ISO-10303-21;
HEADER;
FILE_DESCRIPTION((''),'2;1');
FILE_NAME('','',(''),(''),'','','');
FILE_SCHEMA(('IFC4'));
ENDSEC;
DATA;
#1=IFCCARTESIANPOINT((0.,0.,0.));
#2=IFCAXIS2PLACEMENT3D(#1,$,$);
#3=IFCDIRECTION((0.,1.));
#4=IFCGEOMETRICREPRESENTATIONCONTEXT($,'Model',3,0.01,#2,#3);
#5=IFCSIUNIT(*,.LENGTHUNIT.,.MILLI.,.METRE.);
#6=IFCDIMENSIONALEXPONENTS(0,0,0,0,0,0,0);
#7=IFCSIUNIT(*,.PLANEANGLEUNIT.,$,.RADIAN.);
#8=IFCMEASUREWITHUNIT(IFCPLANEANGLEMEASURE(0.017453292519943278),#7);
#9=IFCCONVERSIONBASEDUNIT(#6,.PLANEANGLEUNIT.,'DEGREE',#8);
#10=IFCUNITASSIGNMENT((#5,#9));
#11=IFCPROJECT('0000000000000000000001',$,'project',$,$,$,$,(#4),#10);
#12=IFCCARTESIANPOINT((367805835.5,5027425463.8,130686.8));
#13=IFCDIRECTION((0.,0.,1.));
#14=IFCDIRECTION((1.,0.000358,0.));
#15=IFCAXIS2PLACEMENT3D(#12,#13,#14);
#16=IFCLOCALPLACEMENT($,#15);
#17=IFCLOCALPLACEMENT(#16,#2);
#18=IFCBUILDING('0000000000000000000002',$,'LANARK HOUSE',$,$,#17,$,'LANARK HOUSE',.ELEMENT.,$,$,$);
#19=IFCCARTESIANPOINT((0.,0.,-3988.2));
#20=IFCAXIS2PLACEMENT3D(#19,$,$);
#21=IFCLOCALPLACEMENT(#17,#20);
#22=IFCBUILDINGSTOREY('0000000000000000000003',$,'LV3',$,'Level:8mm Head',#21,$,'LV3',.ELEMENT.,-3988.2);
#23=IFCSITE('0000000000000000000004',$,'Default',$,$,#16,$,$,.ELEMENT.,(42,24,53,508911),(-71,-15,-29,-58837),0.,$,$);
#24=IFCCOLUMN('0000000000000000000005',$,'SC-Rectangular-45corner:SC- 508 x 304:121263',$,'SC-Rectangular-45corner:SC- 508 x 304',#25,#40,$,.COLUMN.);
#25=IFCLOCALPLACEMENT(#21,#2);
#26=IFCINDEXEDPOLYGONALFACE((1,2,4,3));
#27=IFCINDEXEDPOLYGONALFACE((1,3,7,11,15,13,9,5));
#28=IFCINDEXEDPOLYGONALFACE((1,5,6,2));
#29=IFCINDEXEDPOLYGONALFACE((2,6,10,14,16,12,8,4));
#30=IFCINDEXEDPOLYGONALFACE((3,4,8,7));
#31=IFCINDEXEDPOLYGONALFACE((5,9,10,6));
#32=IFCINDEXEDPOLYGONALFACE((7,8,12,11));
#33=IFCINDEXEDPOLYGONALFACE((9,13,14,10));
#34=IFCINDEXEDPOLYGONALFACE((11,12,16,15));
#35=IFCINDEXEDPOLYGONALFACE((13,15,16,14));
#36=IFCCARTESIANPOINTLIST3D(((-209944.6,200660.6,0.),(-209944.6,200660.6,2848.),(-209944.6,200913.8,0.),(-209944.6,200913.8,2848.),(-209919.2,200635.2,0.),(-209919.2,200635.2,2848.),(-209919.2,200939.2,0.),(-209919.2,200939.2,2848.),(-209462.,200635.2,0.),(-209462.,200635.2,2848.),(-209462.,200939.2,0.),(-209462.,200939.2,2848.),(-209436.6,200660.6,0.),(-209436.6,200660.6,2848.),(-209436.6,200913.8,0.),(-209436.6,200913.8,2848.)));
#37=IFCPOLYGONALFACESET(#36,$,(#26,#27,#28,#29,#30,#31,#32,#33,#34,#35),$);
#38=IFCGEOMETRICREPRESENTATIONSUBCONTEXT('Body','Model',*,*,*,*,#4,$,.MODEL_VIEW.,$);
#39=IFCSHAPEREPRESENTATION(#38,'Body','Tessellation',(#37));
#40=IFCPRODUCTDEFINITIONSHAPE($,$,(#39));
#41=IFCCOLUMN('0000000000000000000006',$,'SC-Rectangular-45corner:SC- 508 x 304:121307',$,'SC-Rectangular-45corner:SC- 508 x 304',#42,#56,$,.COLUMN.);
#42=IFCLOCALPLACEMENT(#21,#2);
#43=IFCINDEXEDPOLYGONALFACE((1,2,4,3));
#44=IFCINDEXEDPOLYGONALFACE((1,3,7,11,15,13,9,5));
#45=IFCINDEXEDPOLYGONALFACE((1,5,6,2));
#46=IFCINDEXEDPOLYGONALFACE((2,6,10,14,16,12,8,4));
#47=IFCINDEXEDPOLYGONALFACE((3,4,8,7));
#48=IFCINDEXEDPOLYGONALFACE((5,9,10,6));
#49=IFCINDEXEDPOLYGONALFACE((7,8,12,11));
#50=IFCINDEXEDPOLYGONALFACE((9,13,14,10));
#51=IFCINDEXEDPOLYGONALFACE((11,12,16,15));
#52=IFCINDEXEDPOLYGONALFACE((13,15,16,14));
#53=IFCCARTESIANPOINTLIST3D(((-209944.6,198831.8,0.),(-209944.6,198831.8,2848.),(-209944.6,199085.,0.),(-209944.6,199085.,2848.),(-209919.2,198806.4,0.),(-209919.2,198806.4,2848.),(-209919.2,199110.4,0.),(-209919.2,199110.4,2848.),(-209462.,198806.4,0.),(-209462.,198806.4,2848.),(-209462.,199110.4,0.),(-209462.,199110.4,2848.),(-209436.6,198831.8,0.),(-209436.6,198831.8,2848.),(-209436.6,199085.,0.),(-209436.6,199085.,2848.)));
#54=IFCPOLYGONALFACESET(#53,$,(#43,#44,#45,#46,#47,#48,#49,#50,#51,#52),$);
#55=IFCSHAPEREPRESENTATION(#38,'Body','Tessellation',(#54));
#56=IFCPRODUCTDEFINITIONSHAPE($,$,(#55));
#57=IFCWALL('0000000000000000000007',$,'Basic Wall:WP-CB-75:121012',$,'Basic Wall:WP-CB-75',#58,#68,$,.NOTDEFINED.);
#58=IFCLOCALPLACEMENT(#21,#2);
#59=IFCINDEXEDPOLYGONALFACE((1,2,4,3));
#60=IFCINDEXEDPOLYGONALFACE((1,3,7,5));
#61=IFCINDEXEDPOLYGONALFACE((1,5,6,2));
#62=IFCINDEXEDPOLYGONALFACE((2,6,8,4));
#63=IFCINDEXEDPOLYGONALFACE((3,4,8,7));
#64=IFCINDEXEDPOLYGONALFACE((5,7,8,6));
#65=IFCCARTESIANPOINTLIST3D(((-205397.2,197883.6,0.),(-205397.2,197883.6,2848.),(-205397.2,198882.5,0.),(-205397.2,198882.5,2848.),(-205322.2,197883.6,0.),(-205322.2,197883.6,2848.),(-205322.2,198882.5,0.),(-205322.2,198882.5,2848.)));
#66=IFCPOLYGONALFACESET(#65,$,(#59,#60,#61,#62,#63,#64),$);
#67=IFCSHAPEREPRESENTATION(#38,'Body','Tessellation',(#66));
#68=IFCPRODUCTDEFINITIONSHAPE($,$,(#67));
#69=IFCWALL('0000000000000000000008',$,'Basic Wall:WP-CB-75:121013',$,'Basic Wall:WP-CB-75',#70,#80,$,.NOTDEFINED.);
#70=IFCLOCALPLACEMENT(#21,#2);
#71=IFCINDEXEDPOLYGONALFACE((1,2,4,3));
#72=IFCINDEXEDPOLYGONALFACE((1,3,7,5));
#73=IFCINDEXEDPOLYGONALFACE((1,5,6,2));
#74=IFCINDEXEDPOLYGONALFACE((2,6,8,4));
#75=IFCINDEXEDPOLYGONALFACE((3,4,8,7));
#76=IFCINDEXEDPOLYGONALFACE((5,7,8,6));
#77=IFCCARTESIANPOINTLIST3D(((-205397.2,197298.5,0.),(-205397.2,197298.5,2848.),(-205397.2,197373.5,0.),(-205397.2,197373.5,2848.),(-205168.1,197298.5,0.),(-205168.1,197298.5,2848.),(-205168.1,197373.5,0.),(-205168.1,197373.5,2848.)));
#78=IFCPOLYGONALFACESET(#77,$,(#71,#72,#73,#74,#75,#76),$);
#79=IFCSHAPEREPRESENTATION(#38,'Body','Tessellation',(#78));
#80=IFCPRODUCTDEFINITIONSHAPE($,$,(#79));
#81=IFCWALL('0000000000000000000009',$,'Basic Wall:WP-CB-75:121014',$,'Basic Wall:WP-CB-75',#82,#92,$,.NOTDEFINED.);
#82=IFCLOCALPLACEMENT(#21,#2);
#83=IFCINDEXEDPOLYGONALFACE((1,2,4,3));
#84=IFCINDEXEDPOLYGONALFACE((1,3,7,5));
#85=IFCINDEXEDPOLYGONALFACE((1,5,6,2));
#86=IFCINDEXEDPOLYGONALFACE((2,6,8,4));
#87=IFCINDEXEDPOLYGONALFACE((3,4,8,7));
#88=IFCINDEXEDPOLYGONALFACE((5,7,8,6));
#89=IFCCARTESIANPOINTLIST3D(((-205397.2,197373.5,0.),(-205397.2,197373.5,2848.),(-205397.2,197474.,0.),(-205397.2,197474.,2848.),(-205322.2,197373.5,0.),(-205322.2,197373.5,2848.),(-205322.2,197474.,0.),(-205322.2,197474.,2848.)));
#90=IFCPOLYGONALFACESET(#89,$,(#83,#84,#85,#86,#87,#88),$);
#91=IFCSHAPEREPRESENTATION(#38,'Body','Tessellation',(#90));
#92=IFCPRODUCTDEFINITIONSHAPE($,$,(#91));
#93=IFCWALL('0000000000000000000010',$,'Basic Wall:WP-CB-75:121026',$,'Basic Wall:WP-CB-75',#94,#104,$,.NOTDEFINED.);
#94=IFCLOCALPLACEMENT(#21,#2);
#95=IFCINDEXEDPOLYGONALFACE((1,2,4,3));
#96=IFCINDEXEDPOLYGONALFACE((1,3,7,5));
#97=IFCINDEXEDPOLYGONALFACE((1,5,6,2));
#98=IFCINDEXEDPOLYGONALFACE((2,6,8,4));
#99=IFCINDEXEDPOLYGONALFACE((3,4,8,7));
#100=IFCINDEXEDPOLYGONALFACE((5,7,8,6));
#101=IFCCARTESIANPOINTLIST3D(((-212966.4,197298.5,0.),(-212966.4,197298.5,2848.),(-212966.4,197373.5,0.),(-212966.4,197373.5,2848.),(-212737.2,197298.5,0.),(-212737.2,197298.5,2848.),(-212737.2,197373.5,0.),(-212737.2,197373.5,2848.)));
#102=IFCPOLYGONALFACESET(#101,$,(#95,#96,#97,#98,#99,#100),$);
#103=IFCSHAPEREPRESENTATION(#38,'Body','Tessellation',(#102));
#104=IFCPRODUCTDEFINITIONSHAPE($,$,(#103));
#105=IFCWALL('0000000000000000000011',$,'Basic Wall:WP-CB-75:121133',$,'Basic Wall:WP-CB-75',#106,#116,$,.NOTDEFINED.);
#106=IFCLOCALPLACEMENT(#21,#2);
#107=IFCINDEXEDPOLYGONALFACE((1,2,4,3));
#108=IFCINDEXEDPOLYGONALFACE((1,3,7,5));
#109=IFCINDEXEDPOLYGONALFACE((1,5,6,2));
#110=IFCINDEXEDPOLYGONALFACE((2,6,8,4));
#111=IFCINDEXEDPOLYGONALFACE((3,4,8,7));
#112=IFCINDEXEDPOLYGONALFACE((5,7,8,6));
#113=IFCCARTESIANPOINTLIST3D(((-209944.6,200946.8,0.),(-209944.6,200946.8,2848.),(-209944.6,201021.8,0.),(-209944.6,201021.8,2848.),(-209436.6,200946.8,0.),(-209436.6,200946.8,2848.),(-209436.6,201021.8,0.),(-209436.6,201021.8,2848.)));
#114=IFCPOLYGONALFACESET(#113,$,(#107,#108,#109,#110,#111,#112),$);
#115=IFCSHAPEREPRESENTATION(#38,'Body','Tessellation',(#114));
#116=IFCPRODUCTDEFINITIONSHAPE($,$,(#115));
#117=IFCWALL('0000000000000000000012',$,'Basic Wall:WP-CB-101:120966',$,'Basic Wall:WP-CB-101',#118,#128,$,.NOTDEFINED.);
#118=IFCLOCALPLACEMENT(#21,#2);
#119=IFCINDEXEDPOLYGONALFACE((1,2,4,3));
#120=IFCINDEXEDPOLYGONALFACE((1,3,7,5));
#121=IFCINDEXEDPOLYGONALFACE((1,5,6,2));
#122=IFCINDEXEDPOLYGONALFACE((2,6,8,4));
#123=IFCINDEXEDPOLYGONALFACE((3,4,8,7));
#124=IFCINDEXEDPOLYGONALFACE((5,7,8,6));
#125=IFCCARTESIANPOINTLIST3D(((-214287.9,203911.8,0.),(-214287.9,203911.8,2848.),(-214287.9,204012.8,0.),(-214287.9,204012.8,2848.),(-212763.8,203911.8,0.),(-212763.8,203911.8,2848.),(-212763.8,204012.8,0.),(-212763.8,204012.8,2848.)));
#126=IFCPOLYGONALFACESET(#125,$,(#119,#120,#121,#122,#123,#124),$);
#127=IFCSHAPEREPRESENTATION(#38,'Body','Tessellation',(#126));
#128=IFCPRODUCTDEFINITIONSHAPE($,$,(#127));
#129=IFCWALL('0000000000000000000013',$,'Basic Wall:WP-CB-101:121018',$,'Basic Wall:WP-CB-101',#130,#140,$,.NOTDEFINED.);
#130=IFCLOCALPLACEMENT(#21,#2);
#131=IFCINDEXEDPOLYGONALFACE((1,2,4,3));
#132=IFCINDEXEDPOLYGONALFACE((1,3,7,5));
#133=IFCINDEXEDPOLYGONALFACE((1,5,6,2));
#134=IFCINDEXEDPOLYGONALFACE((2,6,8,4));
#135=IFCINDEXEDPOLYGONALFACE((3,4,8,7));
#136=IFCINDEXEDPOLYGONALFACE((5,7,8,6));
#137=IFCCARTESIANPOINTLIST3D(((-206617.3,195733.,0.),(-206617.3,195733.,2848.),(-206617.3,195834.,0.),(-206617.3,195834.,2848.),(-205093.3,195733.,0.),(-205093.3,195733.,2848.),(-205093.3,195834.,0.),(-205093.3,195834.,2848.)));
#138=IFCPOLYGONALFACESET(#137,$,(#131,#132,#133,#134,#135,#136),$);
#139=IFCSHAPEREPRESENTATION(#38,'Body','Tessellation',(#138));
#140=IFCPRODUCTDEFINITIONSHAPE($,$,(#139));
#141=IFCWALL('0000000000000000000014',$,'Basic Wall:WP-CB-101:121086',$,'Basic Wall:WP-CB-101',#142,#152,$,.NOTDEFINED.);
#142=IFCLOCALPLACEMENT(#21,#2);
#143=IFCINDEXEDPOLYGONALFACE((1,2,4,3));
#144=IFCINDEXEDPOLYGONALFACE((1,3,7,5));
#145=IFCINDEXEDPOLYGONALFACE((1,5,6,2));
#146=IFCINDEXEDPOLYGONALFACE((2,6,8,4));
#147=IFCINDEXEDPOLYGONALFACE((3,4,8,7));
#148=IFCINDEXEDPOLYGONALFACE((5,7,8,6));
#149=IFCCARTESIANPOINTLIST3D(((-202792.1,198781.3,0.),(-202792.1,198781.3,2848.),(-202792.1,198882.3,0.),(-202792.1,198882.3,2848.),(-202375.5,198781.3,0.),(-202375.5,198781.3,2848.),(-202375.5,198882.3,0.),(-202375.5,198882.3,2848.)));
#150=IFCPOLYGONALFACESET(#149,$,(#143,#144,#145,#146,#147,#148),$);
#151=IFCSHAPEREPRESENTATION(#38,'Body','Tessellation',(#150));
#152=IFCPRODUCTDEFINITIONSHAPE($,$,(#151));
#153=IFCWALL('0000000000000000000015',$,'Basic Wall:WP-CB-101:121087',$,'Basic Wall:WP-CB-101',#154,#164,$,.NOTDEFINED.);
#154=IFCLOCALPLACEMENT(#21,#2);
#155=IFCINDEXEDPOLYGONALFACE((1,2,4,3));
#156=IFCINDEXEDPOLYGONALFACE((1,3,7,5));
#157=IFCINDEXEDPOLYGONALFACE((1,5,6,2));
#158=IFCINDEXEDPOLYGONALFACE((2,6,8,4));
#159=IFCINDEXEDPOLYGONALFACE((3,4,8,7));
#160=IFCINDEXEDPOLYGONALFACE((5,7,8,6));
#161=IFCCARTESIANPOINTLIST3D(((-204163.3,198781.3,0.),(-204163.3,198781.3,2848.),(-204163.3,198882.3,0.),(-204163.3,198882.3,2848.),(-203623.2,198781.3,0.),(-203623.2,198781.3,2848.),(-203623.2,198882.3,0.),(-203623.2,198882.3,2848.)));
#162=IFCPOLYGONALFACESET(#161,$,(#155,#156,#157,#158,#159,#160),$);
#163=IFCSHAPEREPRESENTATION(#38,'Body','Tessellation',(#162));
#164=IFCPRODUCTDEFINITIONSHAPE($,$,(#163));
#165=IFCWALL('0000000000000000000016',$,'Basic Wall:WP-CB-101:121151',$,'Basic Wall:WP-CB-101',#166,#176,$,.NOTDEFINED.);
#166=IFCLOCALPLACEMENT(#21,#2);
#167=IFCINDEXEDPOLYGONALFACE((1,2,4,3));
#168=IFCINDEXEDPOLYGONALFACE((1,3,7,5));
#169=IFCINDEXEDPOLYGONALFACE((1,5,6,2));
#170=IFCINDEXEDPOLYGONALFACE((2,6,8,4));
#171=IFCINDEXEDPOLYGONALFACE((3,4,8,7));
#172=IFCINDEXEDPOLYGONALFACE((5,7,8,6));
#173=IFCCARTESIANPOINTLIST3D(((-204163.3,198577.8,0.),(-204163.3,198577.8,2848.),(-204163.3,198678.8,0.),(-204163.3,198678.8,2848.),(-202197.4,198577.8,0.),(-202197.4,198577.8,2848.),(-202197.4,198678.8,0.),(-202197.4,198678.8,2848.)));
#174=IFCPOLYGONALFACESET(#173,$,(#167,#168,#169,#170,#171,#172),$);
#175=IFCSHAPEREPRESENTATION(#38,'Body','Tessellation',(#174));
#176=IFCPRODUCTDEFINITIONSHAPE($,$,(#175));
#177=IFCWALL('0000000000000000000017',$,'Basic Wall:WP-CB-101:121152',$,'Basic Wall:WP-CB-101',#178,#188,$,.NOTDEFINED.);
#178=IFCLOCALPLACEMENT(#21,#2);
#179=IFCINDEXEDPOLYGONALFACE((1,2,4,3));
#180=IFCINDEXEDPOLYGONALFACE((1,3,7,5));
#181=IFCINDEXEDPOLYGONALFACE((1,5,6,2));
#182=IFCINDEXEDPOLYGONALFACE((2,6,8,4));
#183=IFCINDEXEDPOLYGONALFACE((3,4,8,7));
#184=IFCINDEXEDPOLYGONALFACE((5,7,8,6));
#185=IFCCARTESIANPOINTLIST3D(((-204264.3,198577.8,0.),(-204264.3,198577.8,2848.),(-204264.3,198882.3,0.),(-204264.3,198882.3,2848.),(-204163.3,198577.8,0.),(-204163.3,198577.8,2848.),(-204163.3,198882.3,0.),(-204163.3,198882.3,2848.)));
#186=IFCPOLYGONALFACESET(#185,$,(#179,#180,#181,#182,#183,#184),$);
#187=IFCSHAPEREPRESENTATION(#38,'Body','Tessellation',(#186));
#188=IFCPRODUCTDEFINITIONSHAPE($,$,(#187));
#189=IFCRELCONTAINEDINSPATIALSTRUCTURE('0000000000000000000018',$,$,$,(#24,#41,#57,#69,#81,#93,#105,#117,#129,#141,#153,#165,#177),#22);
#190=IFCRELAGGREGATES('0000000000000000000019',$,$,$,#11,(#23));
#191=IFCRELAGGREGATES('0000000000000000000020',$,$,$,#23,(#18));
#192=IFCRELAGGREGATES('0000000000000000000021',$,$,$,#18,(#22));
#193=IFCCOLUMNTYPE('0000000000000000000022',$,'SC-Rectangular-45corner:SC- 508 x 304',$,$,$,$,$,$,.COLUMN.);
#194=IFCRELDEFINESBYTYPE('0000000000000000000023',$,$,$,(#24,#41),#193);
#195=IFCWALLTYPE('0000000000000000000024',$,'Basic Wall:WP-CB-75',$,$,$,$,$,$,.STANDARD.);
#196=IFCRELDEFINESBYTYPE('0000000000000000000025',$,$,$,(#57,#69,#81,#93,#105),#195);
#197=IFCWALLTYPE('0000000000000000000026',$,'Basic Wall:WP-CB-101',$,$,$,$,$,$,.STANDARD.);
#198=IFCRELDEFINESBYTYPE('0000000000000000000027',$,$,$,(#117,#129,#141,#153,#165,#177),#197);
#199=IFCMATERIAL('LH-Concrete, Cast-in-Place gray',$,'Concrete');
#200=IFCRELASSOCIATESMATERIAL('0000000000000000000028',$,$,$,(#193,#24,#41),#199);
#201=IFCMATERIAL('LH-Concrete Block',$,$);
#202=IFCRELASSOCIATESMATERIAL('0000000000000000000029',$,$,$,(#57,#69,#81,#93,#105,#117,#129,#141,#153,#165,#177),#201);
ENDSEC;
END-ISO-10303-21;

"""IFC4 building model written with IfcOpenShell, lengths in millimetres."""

from ifc_helpers import new_model, entity, si_unit, converted_unit, direction, frame, origin, place, context, subcontext, project, spatial, indexed_curve, outline, extrude, source, transform, mapped, material, type_object, type_shapes, element, save


model = new_model("IFC4")

# Units and contexts
model_context = context("Model", 3, precision=0.01, world=origin(), true_north=direction((0.0, 1.0)))
body_context = subcontext(model_context, "Body", "Model", "MODEL_VIEW")
ifc_project = project(units=[si_unit("LENGTHUNIT", "METRE", prefix="MILLI"), converted_unit("PLANEANGLEUNIT", "DEGREE", entity("IfcPlaneAngleMeasure", 0.017453292519943278), si_unit("PLANEANGLEUNIT", "RADIAN"), dimensions=[0, 0, 0, 0, 0, 0, 0])], contexts=[model_context])

# Site, building, storey
site_placement = place(None, frame((367805835.5, 5027425463.8, 130686.8), z_axis=(0.0, 0.0, 1.0), x_axis=(1.0, 0.000358, 0.0)))
site = spatial("IfcSite", under=ifc_project, at=site_placement, Name="Default", CompositionType="ELEMENT", RefLatitude=(42, 24, 53, 508911), RefLongitude=(-71, -15, -29, -58837), RefElevation=0.0)
building_placement = place(site_placement, origin())
building = spatial("IfcBuilding", under=site, at=building_placement, Name="LANARK HOUSE", LongName="LANARK HOUSE", CompositionType="ELEMENT")
storey_placement = place(building_placement, frame((0.0, 0.0, -3988.2)))
storey = spatial("IfcBuildingStorey", under=building, at=storey_placement, Name="LV3", ObjectType="Level:8mm Head", LongName="LV3", CompositionType="ELEMENT", Elevation=-3988.2)

# Columns
ifc_material_1 = material(Name="LH-Concrete, Cast-in-Place gray", Category="Concrete")
column_type = type_object("IfcColumnType", Name="SC-Rectangular-45corner:SC- 508 x 304", PredefinedType="COLUMN", material=ifc_material_1)
shared_shape = source(origin(), body_context, "Body", "SweptSolid", [
    extrude(outline(indexed_curve([(-228.6, -152.0), (228.6, -152.0), (254.0, -126.6), (254.0, 126.6), (228.6, 152.0), (-228.6, 152.0), (-254.0, 126.6), (-254.0, -126.6), (-228.6, -152.0)], self_intersect=False)), frame((0.0, 0.0, -3988.2), z_axis=(0.0, 0.0, 1.0), x_axis=(-1.0, 0.0, 0.0)), (0.0, 0.0, 1.0), 2848.0),
])
type_shapes(column_type, [shared_shape])
for number, where, name in (
    (1, (-209690.6, 200787.2, 3988.2), "SC-Rectangular-45corner:SC- 508 x 304:121263"),
    (2, (-209690.6, 198958.4, 3988.2), "SC-Rectangular-45corner:SC- 508 x 304:121307"),
):
    element("IfcColumn", number, at=place(storey_placement, frame(where)), inside=storey, type_object=column_type, material=ifc_material_1, Name=name, ObjectType="SC-Rectangular-45corner:SC- 508 x 304", PredefinedType="COLUMN", context=body_context, shape_type="MappedRepresentation", body=[
        mapped(shared_shape, transform((0.0, 0.0, 0.0), scale=1.0)),
    ])

# Walls
ifc_material_2 = material(Name="LH-Concrete Block")
wall_type_1 = type_object("IfcWallType", Name="Basic Wall:WP-CB-75", PredefinedType="STANDARD")
wall_1_placement = place(storey_placement, frame((-205359.7, 198882.5, 0.0), z_axis=(0.0, 0.0, 1.0), x_axis=(0.0, -1.0, 0.0)))
element("IfcWall", 3, at=wall_1_placement, inside=storey, type_object=wall_type_1, material=ifc_material_2, Name="Basic Wall:WP-CB-75:121012", ObjectType="Basic Wall:WP-CB-75", PredefinedType="NOTDEFINED", context=body_context, shape_type="SweptSolid", body=[
    extrude(outline(indexed_curve([(998.9, 37.5), (0.0, 37.5), (0.0, -37.5), (998.9, -37.5), (998.9, 37.5)], self_intersect=False)), origin(), (0.0, 0.0, 1.0), 2848.0),
])
wall_2_placement = place(storey_placement, frame((-205168.1, 197336.0, 0.0), z_axis=(0.0, 0.0, 1.0), x_axis=(-1.0, 0.0, 0.0)))
element("IfcWall", 4, at=wall_2_placement, inside=storey, type_object=wall_type_1, material=ifc_material_2, Name="Basic Wall:WP-CB-75:121013", ObjectType="Basic Wall:WP-CB-75", PredefinedType="NOTDEFINED", context=body_context, shape_type="SweptSolid", body=[
    extrude(outline(indexed_curve([(229.2, 37.5), (0.0, 37.5), (0.0, -37.5), (229.2, -37.5), (229.2, 37.5)], self_intersect=False)), origin(), (0.0, 0.0, 1.0), 2848.0),
])
wall_3_placement = place(storey_placement, frame((-205359.7, 197373.5, 0.0), z_axis=(0.0, 0.0, 1.0), x_axis=(0.0, 1.0, 0.0)))
element("IfcWall", 5, at=wall_3_placement, inside=storey, type_object=wall_type_1, material=ifc_material_2, Name="Basic Wall:WP-CB-75:121014", ObjectType="Basic Wall:WP-CB-75", PredefinedType="NOTDEFINED", context=body_context, shape_type="SweptSolid", body=[
    extrude(outline(indexed_curve([(100.5, 37.5), (0.0, 37.5), (0.0, -37.5), (100.5, -37.5), (100.5, 37.5)], self_intersect=False)), origin(), (0.0, 0.0, 1.0), 2848.0),
])
wall_4_placement = place(storey_placement, frame((-212737.2, 197336.0, 0.0), z_axis=(0.0, 0.0, 1.0), x_axis=(-1.0, 0.0, 0.0)))
element("IfcWall", 6, at=wall_4_placement, inside=storey, type_object=wall_type_1, material=ifc_material_2, Name="Basic Wall:WP-CB-75:121026", ObjectType="Basic Wall:WP-CB-75", PredefinedType="NOTDEFINED", context=body_context, shape_type="SweptSolid", body=[
    extrude(outline(indexed_curve([(229.2, 37.5), (0.0, 37.5), (0.0, -37.5), (229.2, -37.5), (229.2, 37.5)], self_intersect=False)), origin(), (0.0, 0.0, 1.0), 2848.0),
])
wall_5_placement = place(storey_placement, frame((-209944.6, 200984.3, 0.0)))
element("IfcWall", 7, at=wall_5_placement, inside=storey, type_object=wall_type_1, material=ifc_material_2, Name="Basic Wall:WP-CB-75:121133", ObjectType="Basic Wall:WP-CB-75", PredefinedType="NOTDEFINED", context=body_context, shape_type="SweptSolid", body=[
    extrude(outline(indexed_curve([(508.0, 37.5), (0.0, 37.5), (0.0, -37.5), (508.0, -37.5), (508.0, 37.5)], self_intersect=False)), origin(), (0.0, 0.0, 1.0), 2848.0),
])
wall_type_2 = type_object("IfcWallType", Name="Basic Wall:WP-CB-101", PredefinedType="STANDARD")
wall_6_placement = place(storey_placement, frame((-212763.8, 203962.3, 0.0), z_axis=(0.0, 0.0, 1.0), x_axis=(-1.0, 0.0, 0.0)))
element("IfcWall", 8, at=wall_6_placement, inside=storey, type_object=wall_type_2, material=ifc_material_2, Name="Basic Wall:WP-CB-101:120966", ObjectType="Basic Wall:WP-CB-101", PredefinedType="NOTDEFINED", context=body_context, shape_type="SweptSolid", body=[
    extrude(outline(indexed_curve([(1524.1, 50.5), (0.0, 50.5), (0.0, -50.5), (1524.1, -50.5), (1524.1, 50.5)], self_intersect=False)), origin(), (0.0, 0.0, 1.0), 2848.0),
])
wall_7_placement = place(storey_placement, frame((-206617.3, 195783.5, 0.0)))
element("IfcWall", 9, at=wall_7_placement, inside=storey, type_object=wall_type_2, material=ifc_material_2, Name="Basic Wall:WP-CB-101:121018", ObjectType="Basic Wall:WP-CB-101", PredefinedType="NOTDEFINED", context=body_context, shape_type="SweptSolid", body=[
    extrude(outline(indexed_curve([(1524.1, 50.5), (0.0, 50.5), (0.0, -50.5), (1524.1, -50.5), (1524.1, 50.5)], self_intersect=False)), origin(), (0.0, 0.0, 1.0), 2848.0),
])
wall_8_placement = place(storey_placement, frame((-202375.5, 198831.8, 0.0), z_axis=(0.0, 0.0, 1.0), x_axis=(-1.0, 0.0, 0.0)))
element("IfcWall", 10, at=wall_8_placement, inside=storey, type_object=wall_type_2, material=ifc_material_2, Name="Basic Wall:WP-CB-101:121086", ObjectType="Basic Wall:WP-CB-101", PredefinedType="NOTDEFINED", context=body_context, shape_type="SweptSolid", body=[
    extrude(outline(indexed_curve([(416.6, 50.5), (0.0, 50.5), (0.0, -50.5), (416.6, -50.5), (416.6, 50.5)], self_intersect=False)), origin(), (0.0, 0.0, 1.0), 2848.0),
])
wall_9_placement = place(storey_placement, frame((-203623.2, 198831.8, 0.0), z_axis=(0.0, 0.0, 1.0), x_axis=(-1.0, 0.0, 0.0)))
element("IfcWall", 11, at=wall_9_placement, inside=storey, type_object=wall_type_2, material=ifc_material_2, Name="Basic Wall:WP-CB-101:121087", ObjectType="Basic Wall:WP-CB-101", PredefinedType="NOTDEFINED", context=body_context, shape_type="SweptSolid", body=[
    extrude(outline(indexed_curve([(540.1, 50.5), (0.0, 50.5), (0.0, -50.5), (540.1, -50.5), (540.1, 50.5)], self_intersect=False)), origin(), (0.0, 0.0, 1.0), 2848.0),
])
wall_10_placement = place(storey_placement, frame((-202197.4, 198628.3, 0.0), z_axis=(0.0, 0.0, 1.0), x_axis=(-1.0, 0.0, 0.0)))
element("IfcWall", 12, at=wall_10_placement, inside=storey, type_object=wall_type_2, material=ifc_material_2, Name="Basic Wall:WP-CB-101:121151", ObjectType="Basic Wall:WP-CB-101", PredefinedType="NOTDEFINED", context=body_context, shape_type="SweptSolid", body=[
    extrude(outline(indexed_curve([(1965.9, 50.5), (0.0, 50.5), (0.0, -50.5), (1965.9, -50.5), (1965.9, 50.5)], self_intersect=False)), origin(), (0.0, 0.0, 1.0), 2848.0),
])
wall_11_placement = place(storey_placement, frame((-204213.8, 198577.8, 0.0), z_axis=(0.0, 0.0, 1.0), x_axis=(0.0, 1.0, 0.0)))
element("IfcWall", 13, at=wall_11_placement, inside=storey, type_object=wall_type_2, material=ifc_material_2, Name="Basic Wall:WP-CB-101:121152", ObjectType="Basic Wall:WP-CB-101", PredefinedType="NOTDEFINED", context=body_context, shape_type="SweptSolid", body=[
    extrude(outline(indexed_curve([(304.5, 50.5), (0.0, 50.5), (0.0, -50.5), (304.5, -50.5), (304.5, 50.5)], self_intersect=False)), origin(), (0.0, 0.0, 1.0), 2848.0),
])

save(model, "model.ifc")
